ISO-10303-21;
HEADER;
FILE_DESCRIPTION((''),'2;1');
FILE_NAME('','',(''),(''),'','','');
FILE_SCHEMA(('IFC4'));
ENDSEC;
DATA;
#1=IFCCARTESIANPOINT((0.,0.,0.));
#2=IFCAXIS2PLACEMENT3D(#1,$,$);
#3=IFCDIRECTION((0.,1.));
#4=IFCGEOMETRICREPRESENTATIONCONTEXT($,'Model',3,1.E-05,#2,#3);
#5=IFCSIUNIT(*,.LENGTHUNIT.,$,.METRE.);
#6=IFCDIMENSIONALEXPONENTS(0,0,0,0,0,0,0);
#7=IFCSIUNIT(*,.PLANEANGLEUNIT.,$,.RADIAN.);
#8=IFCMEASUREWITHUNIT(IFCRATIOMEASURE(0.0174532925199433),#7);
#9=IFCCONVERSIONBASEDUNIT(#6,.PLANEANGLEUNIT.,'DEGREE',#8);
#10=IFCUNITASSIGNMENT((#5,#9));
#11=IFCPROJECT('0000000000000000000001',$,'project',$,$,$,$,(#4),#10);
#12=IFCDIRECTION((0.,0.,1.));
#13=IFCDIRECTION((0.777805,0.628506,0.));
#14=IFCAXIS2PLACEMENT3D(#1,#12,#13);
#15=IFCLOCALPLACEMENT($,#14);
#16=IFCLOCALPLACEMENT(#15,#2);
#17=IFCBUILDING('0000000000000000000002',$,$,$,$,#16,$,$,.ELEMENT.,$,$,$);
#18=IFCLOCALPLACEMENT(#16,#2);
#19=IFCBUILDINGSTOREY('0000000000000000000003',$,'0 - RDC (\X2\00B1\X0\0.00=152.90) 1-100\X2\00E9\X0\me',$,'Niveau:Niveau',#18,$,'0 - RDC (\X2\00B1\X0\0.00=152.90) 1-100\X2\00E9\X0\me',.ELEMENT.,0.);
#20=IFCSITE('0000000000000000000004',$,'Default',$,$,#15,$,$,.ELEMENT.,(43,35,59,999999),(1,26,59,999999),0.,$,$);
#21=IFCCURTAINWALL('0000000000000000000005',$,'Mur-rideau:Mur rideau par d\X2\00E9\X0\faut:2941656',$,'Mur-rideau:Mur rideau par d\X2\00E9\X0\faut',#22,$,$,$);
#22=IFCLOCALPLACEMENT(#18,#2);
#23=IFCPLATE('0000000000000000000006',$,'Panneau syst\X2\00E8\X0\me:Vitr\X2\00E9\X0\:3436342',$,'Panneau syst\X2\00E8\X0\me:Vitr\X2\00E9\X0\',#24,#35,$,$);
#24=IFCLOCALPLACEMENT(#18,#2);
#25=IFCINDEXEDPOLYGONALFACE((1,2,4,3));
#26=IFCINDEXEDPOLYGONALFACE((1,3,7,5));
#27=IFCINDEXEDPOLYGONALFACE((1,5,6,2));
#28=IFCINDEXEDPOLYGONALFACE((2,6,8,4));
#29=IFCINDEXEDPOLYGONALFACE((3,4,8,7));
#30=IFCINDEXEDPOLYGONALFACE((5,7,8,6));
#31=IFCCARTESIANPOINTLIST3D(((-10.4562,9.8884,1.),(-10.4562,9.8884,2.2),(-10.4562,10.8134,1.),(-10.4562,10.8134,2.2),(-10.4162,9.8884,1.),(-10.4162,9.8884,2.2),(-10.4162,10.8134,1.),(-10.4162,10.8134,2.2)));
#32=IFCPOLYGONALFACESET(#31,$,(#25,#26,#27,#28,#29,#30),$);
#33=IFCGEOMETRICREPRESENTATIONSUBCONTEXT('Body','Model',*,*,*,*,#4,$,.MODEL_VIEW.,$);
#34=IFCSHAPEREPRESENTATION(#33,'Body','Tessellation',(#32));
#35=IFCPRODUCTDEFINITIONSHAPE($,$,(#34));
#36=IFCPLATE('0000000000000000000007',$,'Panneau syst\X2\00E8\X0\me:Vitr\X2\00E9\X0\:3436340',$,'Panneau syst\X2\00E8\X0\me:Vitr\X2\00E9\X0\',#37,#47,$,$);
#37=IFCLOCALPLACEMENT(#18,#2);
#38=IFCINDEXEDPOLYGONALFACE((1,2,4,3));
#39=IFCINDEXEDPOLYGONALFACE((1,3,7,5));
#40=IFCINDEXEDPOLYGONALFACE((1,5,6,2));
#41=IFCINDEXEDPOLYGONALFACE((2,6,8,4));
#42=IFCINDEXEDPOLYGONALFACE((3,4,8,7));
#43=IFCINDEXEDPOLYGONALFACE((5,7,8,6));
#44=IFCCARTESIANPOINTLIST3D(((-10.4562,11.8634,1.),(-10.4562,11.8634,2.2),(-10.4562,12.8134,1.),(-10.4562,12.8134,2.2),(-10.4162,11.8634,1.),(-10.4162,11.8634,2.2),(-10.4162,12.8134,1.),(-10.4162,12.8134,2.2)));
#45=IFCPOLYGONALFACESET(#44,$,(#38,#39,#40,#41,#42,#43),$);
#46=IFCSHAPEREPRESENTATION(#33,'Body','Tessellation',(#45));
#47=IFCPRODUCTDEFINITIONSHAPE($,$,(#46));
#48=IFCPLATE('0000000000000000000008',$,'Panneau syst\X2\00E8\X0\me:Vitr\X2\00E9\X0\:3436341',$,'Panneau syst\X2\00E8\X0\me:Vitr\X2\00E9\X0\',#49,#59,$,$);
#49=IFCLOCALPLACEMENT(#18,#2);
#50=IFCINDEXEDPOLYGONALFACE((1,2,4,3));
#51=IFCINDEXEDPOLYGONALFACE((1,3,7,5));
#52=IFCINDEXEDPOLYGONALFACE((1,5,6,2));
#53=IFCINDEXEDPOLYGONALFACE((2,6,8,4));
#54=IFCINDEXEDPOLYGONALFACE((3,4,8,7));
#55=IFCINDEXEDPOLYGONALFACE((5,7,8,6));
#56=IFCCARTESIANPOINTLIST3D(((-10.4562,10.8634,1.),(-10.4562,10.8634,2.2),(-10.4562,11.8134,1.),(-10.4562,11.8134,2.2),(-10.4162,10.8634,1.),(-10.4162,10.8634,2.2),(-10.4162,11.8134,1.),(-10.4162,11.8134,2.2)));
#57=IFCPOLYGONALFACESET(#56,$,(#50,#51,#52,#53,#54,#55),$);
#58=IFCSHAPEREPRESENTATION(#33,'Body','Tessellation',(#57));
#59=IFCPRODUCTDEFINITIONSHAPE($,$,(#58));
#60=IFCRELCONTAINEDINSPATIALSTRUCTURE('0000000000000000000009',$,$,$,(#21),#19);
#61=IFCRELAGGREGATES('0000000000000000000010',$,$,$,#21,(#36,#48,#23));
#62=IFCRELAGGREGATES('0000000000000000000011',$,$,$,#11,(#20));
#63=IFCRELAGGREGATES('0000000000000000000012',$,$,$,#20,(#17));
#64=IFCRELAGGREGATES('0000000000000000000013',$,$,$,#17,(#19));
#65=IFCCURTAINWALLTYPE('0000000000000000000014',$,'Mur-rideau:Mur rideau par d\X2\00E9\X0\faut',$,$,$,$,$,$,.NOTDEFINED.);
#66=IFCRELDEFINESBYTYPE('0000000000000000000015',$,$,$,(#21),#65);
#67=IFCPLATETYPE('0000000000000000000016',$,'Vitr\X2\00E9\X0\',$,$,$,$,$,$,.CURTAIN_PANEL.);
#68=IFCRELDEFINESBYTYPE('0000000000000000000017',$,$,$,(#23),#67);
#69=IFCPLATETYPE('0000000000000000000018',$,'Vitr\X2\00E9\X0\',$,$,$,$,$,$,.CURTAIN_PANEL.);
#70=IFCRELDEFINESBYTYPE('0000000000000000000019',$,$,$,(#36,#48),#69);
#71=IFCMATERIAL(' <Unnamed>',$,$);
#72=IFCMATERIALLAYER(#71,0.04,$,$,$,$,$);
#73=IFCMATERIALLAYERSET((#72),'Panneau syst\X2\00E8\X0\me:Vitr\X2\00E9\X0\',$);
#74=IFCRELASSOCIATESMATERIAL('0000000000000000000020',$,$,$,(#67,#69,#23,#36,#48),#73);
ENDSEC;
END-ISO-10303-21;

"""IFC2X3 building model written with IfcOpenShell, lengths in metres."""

from ifc_helpers import new_model, entity, si_unit, converted_unit, direction, frame, frame_2d, origin, place, context, subcontext, project, spatial, rectangle, extrude, source, transform, mapped, material, layer, layer_set, layer_usage, type_object, type_shapes, element, aggregate, save


model = new_model("IFC2X3")

# Units and contexts
model_context = context("Model", 3, precision=1e-05, world=origin(), true_north=direction((0.0, 1.0)))
body_context = subcontext(model_context, "Body", "Model", "MODEL_VIEW")
ifc_project = project(units=[si_unit("LENGTHUNIT", "METRE"), converted_unit("PLANEANGLEUNIT", "DEGREE", entity("IfcRatioMeasure", 0.0174532925199433), si_unit("PLANEANGLEUNIT", "RADIAN"), dimensions=[0, 0, 0, 0, 0, 0, 0])], contexts=[model_context])

# Site, building, storey
site_placement = place(None, frame((0.0, 0.0, 0.0), z_axis=(0.0, 0.0, 1.0), x_axis=(0.777805, 0.628506, 0.0)))
site = spatial("IfcSite", under=ifc_project, at=site_placement, Name="Default", CompositionType="ELEMENT", RefLatitude=(43, 35, 59, 999999), RefLongitude=(1, 26, 59, 999999), RefElevation=0.0)
building_placement = place(site_placement, origin())
building = spatial("IfcBuilding", under=site, at=building_placement, CompositionType="ELEMENT")
storey_placement = place(building_placement, origin())
storey = spatial("IfcBuildingStorey", under=building, at=storey_placement, Name="0 - RDC (±0.00=152.90) 1-100éme", ObjectType="Niveau:Niveau", LongName="0 - RDC (±0.00=152.90) 1-100éme", CompositionType="ELEMENT", Elevation=0.0)

# Curtain wall, plates
curtain_wall_type = type_object("IfcCurtainWallType", Name="Mur-rideau:Mur rideau par défaut", PredefinedType="NOTDEFINED")
curtain_wall_placement = place(storey_placement, origin())
curtain_wall = element("IfcCurtainWall", 1, at=curtain_wall_placement, inside=storey, type_object=curtain_wall_type, Name="Mur-rideau:Mur rideau par défaut:2941656", ObjectType="Mur-rideau:Mur rideau par défaut")
ifc_material_1 = material(Name=" <Unnamed>")
ifc_layer = layer(ifc_material_1, 0.04)
ifc_layer_set = layer_set([ifc_layer], Name="Panneau système:Vitré")
plate_type_1 = type_object("IfcPlateType", Name="Vitré", PredefinedType="CURTAIN_PANEL", material=ifc_layer_set)
shared_shape_1 = source(origin(), body_context, "Body", "SweptSolid", [
    extrude(rectangle(XDim=0.04, YDim=0.925, at=frame_2d((0.0, 0.0), x_axis=(1.0, 0.0))), frame((0.0, 0.0, 0.0), z_axis=(0.0, 0.0, 1.0), x_axis=(0.0, 1.0, 0.0)), (0.0, 0.0, 1.0), 1.2),
])
type_shapes(plate_type_1, [shared_shape_1])
ifc_layer_usage_1 = layer_usage(ifc_layer_set, "AXIS3", "POSITIVE", 0.0)
plate_1_placement = place(curtain_wall_placement, frame((-10.4362, 10.3509, 1.0), z_axis=(0.0, 0.0, 1.0), x_axis=(0.0, -1.0, 0.0)))
plate_1 = element("IfcPlate", 2, at=plate_1_placement, type_object=plate_type_1, material=ifc_layer_usage_1, Name="Panneau système:Vitré:3436342", ObjectType="Panneau système:Vitré", context=body_context, shape_type="MappedRepresentation", body=[
    mapped(shared_shape_1, transform((0.0, 0.0, 0.0), scale=1.0)),
])
ifc_layer_usage_2 = layer_usage(ifc_layer_set, "AXIS3", "POSITIVE", 0.0)
plate_type_2 = type_object("IfcPlateType", Name="Vitré", PredefinedType="CURTAIN_PANEL", material=ifc_layer_set)
shared_shape_2 = source(origin(), body_context, "Body", "SweptSolid", [
    extrude(rectangle(XDim=0.04, YDim=0.95, at=frame_2d((0.0, 0.0), x_axis=(1.0, 0.0))), frame((0.0, 0.0, 0.0), z_axis=(0.0, 0.0, 1.0), x_axis=(0.0, 1.0, 0.0)), (0.0, 0.0, 1.0), 1.2),
])
type_shapes(plate_type_2, [shared_shape_2])
plate_2_placement = place(curtain_wall_placement, frame((-10.4362, 12.3384, 1.0), z_axis=(0.0, 0.0, 1.0), x_axis=(0.0, -1.0, 0.0)))
plate_2 = element("IfcPlate", 3, at=plate_2_placement, type_object=plate_type_2, material=ifc_layer_usage_2, Name="Panneau système:Vitré:3436340", ObjectType="Panneau système:Vitré", context=body_context, shape_type="MappedRepresentation", body=[
    mapped(shared_shape_2, transform((0.0, 0.0, 0.0), scale=1.0)),
])
ifc_layer_usage_3 = layer_usage(ifc_layer_set, "AXIS3", "POSITIVE", 0.0)
plate_3_placement = place(curtain_wall_placement, frame((-10.4362, 11.3384, 1.0), z_axis=(0.0, 0.0, 1.0), x_axis=(0.0, -1.0, 0.0)))
plate_3 = element("IfcPlate", 4, at=plate_3_placement, type_object=plate_type_2, material=ifc_layer_usage_3, Name="Panneau système:Vitré:3436341", ObjectType="Panneau système:Vitré", context=body_context, shape_type="MappedRepresentation", body=[
    mapped(shared_shape_2, transform((0.0, 0.0, 0.0), scale=1.0)),
])
aggregate(curtain_wall, [plate_2, plate_3, plate_1])

save(model, "model.ifc")
